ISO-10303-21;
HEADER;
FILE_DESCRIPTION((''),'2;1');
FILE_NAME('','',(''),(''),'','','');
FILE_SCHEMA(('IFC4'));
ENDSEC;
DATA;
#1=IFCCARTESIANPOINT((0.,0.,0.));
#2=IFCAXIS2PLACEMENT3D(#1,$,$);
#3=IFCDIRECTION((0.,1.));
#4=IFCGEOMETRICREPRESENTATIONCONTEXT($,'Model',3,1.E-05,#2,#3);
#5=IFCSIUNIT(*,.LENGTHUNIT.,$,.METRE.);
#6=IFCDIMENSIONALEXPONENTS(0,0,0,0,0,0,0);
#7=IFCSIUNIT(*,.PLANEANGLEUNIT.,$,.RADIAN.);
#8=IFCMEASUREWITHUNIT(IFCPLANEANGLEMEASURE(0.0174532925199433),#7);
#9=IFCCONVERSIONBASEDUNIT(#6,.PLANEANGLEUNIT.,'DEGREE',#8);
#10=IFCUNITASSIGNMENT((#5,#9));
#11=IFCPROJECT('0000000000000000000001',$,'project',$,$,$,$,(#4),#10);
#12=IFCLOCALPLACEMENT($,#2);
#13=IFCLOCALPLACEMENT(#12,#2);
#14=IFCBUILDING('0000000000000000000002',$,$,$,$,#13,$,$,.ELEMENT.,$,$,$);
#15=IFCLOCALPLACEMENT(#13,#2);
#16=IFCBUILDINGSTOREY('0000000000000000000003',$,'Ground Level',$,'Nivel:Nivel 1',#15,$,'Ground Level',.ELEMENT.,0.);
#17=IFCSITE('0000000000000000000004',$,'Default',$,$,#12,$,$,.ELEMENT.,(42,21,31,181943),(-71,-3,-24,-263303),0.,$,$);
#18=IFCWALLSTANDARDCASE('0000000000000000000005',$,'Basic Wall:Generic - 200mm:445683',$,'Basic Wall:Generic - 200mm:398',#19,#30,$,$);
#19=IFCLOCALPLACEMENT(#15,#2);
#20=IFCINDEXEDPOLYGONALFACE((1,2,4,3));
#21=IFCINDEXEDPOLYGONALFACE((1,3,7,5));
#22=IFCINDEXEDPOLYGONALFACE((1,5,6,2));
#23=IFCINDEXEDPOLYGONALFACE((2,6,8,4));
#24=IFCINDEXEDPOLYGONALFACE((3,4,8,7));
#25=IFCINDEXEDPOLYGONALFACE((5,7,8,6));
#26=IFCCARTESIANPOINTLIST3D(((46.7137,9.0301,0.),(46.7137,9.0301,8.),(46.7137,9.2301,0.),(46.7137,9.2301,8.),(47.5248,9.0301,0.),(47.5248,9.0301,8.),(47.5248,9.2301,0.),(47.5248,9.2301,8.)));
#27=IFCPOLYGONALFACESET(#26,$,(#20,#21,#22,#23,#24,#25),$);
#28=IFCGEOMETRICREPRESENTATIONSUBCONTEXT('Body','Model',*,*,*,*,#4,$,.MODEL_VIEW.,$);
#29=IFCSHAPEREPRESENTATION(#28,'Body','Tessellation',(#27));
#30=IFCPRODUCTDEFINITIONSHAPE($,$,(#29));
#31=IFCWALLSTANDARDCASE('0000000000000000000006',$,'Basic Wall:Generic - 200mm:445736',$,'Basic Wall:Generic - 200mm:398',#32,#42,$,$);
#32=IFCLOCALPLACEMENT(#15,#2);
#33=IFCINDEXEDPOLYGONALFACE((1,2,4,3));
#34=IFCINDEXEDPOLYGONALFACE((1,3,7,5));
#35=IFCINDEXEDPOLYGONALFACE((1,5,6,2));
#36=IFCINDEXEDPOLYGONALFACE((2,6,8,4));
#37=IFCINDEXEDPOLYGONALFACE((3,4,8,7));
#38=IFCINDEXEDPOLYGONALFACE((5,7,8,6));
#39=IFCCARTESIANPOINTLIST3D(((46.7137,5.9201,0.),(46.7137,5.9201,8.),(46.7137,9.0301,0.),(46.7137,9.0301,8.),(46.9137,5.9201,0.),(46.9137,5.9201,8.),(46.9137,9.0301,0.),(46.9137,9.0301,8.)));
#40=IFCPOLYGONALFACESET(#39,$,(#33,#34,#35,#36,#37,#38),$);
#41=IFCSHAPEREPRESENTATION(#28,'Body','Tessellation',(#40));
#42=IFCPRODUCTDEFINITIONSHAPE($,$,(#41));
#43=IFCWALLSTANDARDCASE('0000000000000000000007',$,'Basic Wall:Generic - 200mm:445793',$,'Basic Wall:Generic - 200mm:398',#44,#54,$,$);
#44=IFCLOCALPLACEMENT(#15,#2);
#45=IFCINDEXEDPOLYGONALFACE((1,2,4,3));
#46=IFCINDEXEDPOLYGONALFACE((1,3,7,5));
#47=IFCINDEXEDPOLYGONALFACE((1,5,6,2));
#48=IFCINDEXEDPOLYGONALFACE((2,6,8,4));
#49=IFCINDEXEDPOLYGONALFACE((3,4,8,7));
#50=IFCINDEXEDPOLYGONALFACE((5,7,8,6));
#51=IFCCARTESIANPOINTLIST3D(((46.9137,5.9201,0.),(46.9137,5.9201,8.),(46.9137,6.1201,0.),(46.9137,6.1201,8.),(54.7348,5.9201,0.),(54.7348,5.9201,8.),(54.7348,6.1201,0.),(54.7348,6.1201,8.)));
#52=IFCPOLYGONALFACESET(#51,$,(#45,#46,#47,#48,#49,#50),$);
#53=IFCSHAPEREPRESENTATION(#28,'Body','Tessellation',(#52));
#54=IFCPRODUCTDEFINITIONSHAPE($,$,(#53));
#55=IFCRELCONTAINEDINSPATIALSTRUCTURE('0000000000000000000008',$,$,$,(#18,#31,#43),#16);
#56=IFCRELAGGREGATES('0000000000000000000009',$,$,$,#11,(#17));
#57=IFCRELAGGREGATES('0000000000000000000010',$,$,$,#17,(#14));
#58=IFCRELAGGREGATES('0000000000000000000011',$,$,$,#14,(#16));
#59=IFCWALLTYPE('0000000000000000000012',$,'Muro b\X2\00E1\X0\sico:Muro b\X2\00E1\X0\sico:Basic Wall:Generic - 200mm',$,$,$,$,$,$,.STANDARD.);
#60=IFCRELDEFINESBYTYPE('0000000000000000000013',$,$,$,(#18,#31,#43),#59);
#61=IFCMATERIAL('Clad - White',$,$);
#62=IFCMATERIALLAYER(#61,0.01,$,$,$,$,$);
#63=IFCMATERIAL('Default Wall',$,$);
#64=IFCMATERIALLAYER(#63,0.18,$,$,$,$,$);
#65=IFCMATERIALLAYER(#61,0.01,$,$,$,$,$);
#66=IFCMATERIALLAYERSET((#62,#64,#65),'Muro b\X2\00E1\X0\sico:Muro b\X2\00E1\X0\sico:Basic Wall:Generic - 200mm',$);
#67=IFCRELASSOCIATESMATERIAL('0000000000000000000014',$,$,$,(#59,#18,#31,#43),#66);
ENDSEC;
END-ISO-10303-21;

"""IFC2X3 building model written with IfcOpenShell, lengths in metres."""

from ifc_helpers import new_model, entity, si_unit, converted_unit, direction, frame, frame_2d, origin, place, context, subcontext, project, spatial, rectangle, extrude, material, layer, layer_set, layer_usage, type_object, element, save


model = new_model("IFC2X3")

# Units and contexts
model_context = context("Model", 3, precision=1e-05, world=origin(), true_north=direction((0.0, 1.0)))
body_context = subcontext(model_context, "Body", "Model", "MODEL_VIEW")
ifc_project = project(units=[si_unit("LENGTHUNIT", "METRE"), converted_unit("PLANEANGLEUNIT", "DEGREE", entity("IfcPlaneAngleMeasure", 0.0174532925199433), si_unit("PLANEANGLEUNIT", "RADIAN"), dimensions=[0, 0, 0, 0, 0, 0, 0])], contexts=[model_context])

# Site, building, storey
site_placement = place(None, origin())
site = spatial("IfcSite", under=ifc_project, at=site_placement, Name="Default", CompositionType="ELEMENT", RefLatitude=(42, 21, 31, 181943), RefLongitude=(-71, -3, -24, -263303), RefElevation=0.0)
building_placement = place(site_placement, origin())
building = spatial("IfcBuilding", under=site, at=building_placement, CompositionType="ELEMENT")
storey_placement = place(building_placement, origin())
storey = spatial("IfcBuildingStorey", under=building, at=storey_placement, Name="Ground Level", ObjectType="Nivel:Nivel 1", LongName="Ground Level", CompositionType="ELEMENT", Elevation=0.0)

# Shared definitions
ifc_material_1 = material(Name="Default Wall")

# Walls
ifc_material_2 = material(Name="Clad - White")
ifc_layer_1 = layer(ifc_material_2, 0.01)
ifc_layer_2 = layer(ifc_material_1, 0.18)
ifc_layer_3 = layer(ifc_material_2, 0.01)
ifc_layer_set_1 = layer_set([ifc_layer_1, ifc_layer_2, ifc_layer_3], Name="Muro básico:Muro básico:Basic Wall:Generic - 200mm")
wall_type_1 = type_object("IfcWallType", Name="Muro básico:Muro básico:Basic Wall:Generic - 200mm", PredefinedType="STANDARD", material=ifc_layer_set_1)
ifc_layer_usage_1 = layer_usage(ifc_layer_set_1, "AXIS2", "NEGATIVE", 0.1)
wall_1_placement = place(storey_placement, frame((47.5248, 9.1301, 0.0), z_axis=(0.0, 0.0, 1.0), x_axis=(-1.0, 0.0, 0.0)))
element("IfcWallStandardCase", 1, at=wall_1_placement, inside=storey, type_object=wall_type_1, material=ifc_layer_usage_1, Name="Basic Wall:Generic - 200mm:445683", ObjectType="Basic Wall:Generic - 200mm:398", context=body_context, shape_type="SweptSolid", body=[
    extrude(rectangle(XDim=0.8111, YDim=0.2, at=frame_2d((0.4056, 0.0), x_axis=(-1.0, 0.0))), origin(), (0.0, 0.0, 1.0), 8.0),
])
ifc_layer_usage_2 = layer_usage(ifc_layer_set_1, "AXIS2", "NEGATIVE", 0.1)
wall_2_placement = place(storey_placement, frame((46.8137, 9.0301, 0.0), z_axis=(0.0, 0.0, 1.0), x_axis=(0.0, -1.0, 0.0)))
element("IfcWallStandardCase", 2, at=wall_2_placement, inside=storey, type_object=wall_type_1, material=ifc_layer_usage_2, Name="Basic Wall:Generic - 200mm:445736", ObjectType="Basic Wall:Generic - 200mm:398", context=body_context, shape_type="SweptSolid", body=[
    extrude(rectangle(XDim=3.11, YDim=0.2, at=frame_2d((1.555, 0.0), x_axis=(-1.0, 0.0))), origin(), (0.0, 0.0, 1.0), 8.0),
])
ifc_layer_usage_3 = layer_usage(ifc_layer_set_1, "AXIS2", "NEGATIVE", 0.1)
wall_3_placement = place(storey_placement, frame((46.9137, 6.0201, 0.0)))
element("IfcWallStandardCase", 3, at=wall_3_placement, inside=storey, type_object=wall_type_1, material=ifc_layer_usage_3, Name="Basic Wall:Generic - 200mm:445793", ObjectType="Basic Wall:Generic - 200mm:398", context=body_context, shape_type="SweptSolid", body=[
    extrude(rectangle(XDim=7.8211, YDim=0.2, at=frame_2d((3.9106, 0.0), x_axis=(-1.0, 0.0))), origin(), (0.0, 0.0, 1.0), 8.0),
])

save(model, "model.ifc")
